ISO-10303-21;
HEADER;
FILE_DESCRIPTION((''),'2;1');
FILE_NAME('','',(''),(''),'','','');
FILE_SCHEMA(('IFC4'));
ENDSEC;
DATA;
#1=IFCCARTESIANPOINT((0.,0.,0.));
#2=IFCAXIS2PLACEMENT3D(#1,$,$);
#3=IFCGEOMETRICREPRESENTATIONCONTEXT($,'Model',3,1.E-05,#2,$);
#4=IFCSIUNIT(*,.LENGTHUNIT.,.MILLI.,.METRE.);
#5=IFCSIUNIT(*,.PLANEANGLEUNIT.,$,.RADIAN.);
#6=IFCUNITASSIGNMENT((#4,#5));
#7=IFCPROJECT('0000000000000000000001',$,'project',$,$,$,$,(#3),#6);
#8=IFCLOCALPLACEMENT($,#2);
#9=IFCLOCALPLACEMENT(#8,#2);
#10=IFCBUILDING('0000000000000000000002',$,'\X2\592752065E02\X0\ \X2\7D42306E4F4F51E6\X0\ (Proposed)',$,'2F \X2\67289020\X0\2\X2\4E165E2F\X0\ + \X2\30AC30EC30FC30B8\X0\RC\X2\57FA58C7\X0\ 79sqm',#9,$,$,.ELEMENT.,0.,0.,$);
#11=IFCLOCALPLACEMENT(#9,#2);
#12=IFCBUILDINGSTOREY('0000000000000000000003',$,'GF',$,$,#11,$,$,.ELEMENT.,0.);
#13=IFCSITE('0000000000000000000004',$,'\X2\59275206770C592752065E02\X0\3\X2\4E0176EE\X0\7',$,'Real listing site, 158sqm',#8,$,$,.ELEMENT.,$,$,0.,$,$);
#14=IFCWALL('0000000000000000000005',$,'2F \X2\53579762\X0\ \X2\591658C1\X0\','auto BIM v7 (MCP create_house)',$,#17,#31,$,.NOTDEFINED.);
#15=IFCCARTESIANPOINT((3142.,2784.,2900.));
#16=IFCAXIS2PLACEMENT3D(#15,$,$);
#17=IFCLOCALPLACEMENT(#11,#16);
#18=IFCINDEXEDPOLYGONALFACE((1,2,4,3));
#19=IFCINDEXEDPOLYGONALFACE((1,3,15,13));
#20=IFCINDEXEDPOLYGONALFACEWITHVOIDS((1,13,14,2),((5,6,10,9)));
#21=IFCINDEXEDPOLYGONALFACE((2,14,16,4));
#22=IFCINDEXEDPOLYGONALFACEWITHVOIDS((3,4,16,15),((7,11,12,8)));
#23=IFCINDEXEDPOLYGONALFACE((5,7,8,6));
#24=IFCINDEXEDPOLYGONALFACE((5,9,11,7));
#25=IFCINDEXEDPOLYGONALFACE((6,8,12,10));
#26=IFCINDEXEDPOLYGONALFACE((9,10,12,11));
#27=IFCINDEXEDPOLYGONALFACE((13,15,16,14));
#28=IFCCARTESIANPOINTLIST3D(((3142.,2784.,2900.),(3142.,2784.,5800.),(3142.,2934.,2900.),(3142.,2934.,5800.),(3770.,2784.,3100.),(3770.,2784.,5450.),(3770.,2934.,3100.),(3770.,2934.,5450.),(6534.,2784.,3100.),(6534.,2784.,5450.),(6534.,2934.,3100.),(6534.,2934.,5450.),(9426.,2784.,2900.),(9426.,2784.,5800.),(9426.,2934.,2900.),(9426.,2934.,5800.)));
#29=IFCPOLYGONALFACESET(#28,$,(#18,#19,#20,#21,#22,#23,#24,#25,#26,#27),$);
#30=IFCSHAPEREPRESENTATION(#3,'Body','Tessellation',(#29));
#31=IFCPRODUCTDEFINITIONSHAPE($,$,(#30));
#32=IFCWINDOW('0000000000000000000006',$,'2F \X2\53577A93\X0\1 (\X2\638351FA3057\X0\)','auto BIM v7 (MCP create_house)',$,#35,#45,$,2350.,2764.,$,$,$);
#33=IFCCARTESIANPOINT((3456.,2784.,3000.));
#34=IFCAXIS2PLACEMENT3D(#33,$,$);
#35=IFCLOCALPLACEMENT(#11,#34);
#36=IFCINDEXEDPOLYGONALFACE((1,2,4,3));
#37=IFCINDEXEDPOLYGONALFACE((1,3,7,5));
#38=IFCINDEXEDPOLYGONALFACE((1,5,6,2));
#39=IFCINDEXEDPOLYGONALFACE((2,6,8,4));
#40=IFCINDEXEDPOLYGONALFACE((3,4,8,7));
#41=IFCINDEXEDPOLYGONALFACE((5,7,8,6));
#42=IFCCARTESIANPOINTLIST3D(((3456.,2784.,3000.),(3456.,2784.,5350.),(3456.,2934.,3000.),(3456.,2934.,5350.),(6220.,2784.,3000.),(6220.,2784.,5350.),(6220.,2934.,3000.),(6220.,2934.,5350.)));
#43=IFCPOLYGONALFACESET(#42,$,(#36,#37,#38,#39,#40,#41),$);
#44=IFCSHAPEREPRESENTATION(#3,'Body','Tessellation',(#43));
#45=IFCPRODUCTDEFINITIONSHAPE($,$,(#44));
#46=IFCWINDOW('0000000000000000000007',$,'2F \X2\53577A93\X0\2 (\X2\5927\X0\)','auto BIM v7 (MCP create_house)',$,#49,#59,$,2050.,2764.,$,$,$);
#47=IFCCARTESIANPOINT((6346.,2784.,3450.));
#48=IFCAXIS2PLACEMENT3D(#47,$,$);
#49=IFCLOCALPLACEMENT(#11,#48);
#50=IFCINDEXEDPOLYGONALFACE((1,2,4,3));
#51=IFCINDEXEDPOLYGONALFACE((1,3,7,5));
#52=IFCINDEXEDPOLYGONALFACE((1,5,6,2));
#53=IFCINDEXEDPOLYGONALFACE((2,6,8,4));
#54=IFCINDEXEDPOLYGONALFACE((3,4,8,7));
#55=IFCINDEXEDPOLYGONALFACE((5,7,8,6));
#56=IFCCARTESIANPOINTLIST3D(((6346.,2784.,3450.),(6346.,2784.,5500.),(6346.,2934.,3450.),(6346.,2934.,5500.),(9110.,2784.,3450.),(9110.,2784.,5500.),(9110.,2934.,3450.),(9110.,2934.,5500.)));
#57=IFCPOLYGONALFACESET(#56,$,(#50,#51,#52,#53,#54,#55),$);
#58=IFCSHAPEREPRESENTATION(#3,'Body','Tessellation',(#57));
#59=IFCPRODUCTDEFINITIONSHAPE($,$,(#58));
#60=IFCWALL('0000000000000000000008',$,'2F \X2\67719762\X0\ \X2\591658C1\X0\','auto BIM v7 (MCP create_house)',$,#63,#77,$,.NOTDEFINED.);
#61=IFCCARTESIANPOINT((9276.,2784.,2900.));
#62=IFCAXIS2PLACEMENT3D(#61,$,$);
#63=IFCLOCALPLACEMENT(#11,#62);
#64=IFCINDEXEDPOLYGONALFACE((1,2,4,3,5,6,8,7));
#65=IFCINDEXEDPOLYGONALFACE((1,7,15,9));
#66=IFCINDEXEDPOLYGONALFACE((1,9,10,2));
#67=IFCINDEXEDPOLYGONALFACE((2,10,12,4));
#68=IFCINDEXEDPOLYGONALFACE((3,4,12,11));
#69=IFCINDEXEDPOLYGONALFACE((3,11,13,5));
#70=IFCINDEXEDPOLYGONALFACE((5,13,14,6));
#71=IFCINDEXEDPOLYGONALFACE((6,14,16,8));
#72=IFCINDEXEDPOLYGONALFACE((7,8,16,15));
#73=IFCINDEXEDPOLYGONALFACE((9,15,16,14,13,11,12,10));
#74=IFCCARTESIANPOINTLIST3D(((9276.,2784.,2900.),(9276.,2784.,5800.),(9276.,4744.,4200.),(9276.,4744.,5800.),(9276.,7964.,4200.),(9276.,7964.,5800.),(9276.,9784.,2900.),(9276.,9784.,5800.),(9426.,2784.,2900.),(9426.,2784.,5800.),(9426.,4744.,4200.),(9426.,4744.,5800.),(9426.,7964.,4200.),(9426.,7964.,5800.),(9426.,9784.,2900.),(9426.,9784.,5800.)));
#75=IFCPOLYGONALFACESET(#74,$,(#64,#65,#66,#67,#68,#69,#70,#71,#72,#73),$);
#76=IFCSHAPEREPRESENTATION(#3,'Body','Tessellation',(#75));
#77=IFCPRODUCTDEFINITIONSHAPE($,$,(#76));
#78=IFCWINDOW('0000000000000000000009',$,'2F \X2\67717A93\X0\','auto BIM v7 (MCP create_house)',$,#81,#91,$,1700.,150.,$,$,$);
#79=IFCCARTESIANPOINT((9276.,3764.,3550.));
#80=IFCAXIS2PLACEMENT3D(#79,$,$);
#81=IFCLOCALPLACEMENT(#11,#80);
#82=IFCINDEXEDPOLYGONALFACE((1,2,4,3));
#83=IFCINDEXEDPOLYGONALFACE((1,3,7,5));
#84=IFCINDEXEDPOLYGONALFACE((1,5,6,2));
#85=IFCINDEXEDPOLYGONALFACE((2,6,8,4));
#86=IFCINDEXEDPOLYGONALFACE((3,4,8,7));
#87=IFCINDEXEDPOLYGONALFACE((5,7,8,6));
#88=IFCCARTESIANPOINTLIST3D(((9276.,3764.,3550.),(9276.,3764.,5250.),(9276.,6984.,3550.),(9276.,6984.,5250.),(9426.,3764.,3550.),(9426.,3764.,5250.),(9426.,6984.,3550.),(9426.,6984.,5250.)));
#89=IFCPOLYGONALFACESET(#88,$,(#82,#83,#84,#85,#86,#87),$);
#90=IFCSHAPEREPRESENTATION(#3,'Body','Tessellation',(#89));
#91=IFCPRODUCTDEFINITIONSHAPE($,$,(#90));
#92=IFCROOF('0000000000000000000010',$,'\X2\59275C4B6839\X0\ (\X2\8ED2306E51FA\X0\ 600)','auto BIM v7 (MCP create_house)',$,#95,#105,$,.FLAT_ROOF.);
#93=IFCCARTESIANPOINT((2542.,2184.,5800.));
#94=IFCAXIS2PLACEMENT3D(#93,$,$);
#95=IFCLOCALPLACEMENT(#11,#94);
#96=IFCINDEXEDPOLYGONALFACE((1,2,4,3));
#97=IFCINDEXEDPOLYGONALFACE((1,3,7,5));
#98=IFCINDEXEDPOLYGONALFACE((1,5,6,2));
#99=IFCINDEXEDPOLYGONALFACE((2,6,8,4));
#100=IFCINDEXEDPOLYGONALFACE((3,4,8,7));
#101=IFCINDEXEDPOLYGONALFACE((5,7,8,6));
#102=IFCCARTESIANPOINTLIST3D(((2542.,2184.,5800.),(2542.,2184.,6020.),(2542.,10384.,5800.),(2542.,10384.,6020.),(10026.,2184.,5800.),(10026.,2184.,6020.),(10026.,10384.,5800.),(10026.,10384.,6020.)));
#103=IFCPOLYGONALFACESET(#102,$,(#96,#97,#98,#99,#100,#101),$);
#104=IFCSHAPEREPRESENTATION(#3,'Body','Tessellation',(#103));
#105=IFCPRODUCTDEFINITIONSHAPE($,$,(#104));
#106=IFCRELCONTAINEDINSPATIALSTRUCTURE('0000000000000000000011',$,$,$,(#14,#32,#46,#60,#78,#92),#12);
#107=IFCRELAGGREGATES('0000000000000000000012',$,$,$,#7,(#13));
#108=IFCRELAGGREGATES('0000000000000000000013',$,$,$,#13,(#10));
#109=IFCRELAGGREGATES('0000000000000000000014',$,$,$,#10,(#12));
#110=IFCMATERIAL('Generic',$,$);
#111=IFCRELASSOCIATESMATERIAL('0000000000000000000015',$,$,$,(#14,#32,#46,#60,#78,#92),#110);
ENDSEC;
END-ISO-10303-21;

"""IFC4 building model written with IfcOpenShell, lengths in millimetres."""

from ifc_helpers import new_model, si_unit, frame, frame_2d, origin, place, context, project, spatial, rectangle, extrude, material, element, fill, save


model = new_model("IFC4")

# Units and contexts
model_context = context("Model", 3, precision=1e-05, world=origin())
ifc_project = project(units=[si_unit("LENGTHUNIT", "METRE", prefix="MILLI"), si_unit("PLANEANGLEUNIT", "RADIAN")], contexts=[model_context])

# Site, building, storey
site_placement = place(None, origin())
site = spatial("IfcSite", under=ifc_project, at=site_placement, Name="大分県大分市3丁目7", ObjectType="Real listing site, 158sqm", CompositionType="ELEMENT", RefElevation=0.0)
building_placement = place(site_placement, origin())
building = spatial("IfcBuilding", under=site, at=building_placement, Name="大分市 終の住処 (Proposed)", ObjectType="2F 木造2世帯 + ガレージRC基壇 79sqm", CompositionType="ELEMENT", ElevationOfRefHeight=0.0, ElevationOfTerrain=0.0)
storey_placement = place(building_placement, origin())
storey = spatial("IfcBuildingStorey", under=building, at=storey_placement, Name="GF", CompositionType="ELEMENT", Elevation=0.0)

# Shared definitions
ifc_material = material(Name="Generic")

# Wall, openings, windows
wall_1_placement = place(storey_placement, frame((3142.0, 2784.0, 2900.0)))
wall_1 = element("IfcWall", 1, at=wall_1_placement, inside=storey, material=ifc_material, Name="2F 南面 外壁", Description="auto BIM v7 (MCP create_house)", PredefinedType="NOTDEFINED", context=model_context, shape_type="SweptSolid", body=[
    extrude(rectangle(XDim=6284.0, YDim=150.0, at=frame_2d((3142.0, 75.0))), frame((3142.0, 2784.0, 2900.0)), (0.0, 0.0, 1.0), 2900.0),
])
opening_1_placement = place(storey_placement, frame((3456.0, 2784.0, 3000.0)))
opening_1 = element("IfcOpeningElement", 2, at=opening_1_placement, cuts=wall_1, PredefinedType="NOTDEFINED", context=model_context, shape_type="SweptSolid", body=[
    extrude(rectangle(XDim=2764.0, YDim=150.0, at=frame_2d((1382.0, 75.0))), frame((3456.0, 2784.0, 3000.0)), (0.0, 0.0, 1.0), 2350.0),
])
opening_2_placement = place(storey_placement, frame((6346.0, 2784.0, 3450.0)))
opening_2 = element("IfcOpeningElement", 3, at=opening_2_placement, cuts=wall_1, PredefinedType="NOTDEFINED", context=model_context, shape_type="SweptSolid", body=[
    extrude(rectangle(XDim=2764.0, YDim=150.0, at=frame_2d((1382.0, 75.0))), frame((6346.0, 2784.0, 3450.0)), (0.0, 0.0, 1.0), 2050.0),
])
window_1_placement = place(storey_placement, frame((3456.0, 2784.0, 3000.0)))
window_1 = element("IfcWindow", 4, at=window_1_placement, inside=storey, material=ifc_material, Name="2F 南窓1 (掃出し)", Description="auto BIM v7 (MCP create_house)", OverallHeight=2350.0, OverallWidth=2764.0, context=model_context, shape_type="SweptSolid", body=[
    extrude(rectangle(XDim=2764.0, YDim=150.0, at=frame_2d((1382.0, 75.0))), frame((3456.0, 2784.0, 3000.0)), (0.0, 0.0, 1.0), 2350.0),
])
fill(opening_1, window_1)
window_2_placement = place(storey_placement, frame((6346.0, 2784.0, 3450.0)))
window_2 = element("IfcWindow", 5, at=window_2_placement, inside=storey, material=ifc_material, Name="2F 南窓2 (大)", Description="auto BIM v7 (MCP create_house)", OverallHeight=2050.0, OverallWidth=2764.0, context=model_context, shape_type="SweptSolid", body=[
    extrude(rectangle(XDim=2764.0, YDim=150.0, at=frame_2d((1382.0, 75.0))), frame((6346.0, 2784.0, 3450.0)), (0.0, 0.0, 1.0), 2050.0),
])
fill(opening_2, window_2)

# Wall, opening, window
wall_2_placement = place(storey_placement, frame((9276.0, 2784.0, 2900.0)))
wall_2 = element("IfcWall", 6, at=wall_2_placement, inside=storey, material=ifc_material, Name="2F 東面 外壁", Description="auto BIM v7 (MCP create_house)", PredefinedType="NOTDEFINED", context=model_context, shape_type="SweptSolid", body=[
    extrude(rectangle(XDim=150.0, YDim=7000.0, at=frame_2d((75.0, 3500.0))), frame((9276.0, 2784.0, 2900.0)), (0.0, 0.0, 1.0), 2900.0),
])
opening_3_placement = place(storey_placement, frame((9276.0, 3764.0, 3550.0)))
opening_3 = element("IfcOpeningElement", 7, at=opening_3_placement, cuts=wall_2, PredefinedType="NOTDEFINED", context=model_context, shape_type="SweptSolid", body=[
    extrude(rectangle(XDim=150.0, YDim=3220.0, at=frame_2d((75.0, 1610.0))), frame((9276.0, 3764.0, 3550.0)), (0.0, 0.0, 1.0), 1700.0),
])
window_3_placement = place(storey_placement, frame((9276.0, 3764.0, 3550.0)))
window_3 = element("IfcWindow", 8, at=window_3_placement, inside=storey, material=ifc_material, Name="2F 東窓", Description="auto BIM v7 (MCP create_house)", OverallHeight=1700.0, OverallWidth=150.0, context=model_context, shape_type="SweptSolid", body=[
    extrude(rectangle(XDim=150.0, YDim=3220.0, at=frame_2d((75.0, 1610.0))), frame((9276.0, 3764.0, 3550.0)), (0.0, 0.0, 1.0), 1700.0),
])
fill(opening_3, window_3)

# Roof
roof_placement = place(storey_placement, frame((2542.0, 2184.0, 5800.0)))
element("IfcRoof", 9, at=roof_placement, inside=storey, material=ifc_material, Name="大屋根 (軒の出 600)", Description="auto BIM v7 (MCP create_house)", PredefinedType="FLAT_ROOF", context=model_context, shape_type="SweptSolid", body=[
    extrude(rectangle(XDim=7484.0, YDim=8200.0, at=frame_2d((3742.0, 4100.0))), frame((2542.0, 2184.0, 5800.0)), (0.0, 0.0, 1.0), 220.0),
])

save(model, "model.ifc")
